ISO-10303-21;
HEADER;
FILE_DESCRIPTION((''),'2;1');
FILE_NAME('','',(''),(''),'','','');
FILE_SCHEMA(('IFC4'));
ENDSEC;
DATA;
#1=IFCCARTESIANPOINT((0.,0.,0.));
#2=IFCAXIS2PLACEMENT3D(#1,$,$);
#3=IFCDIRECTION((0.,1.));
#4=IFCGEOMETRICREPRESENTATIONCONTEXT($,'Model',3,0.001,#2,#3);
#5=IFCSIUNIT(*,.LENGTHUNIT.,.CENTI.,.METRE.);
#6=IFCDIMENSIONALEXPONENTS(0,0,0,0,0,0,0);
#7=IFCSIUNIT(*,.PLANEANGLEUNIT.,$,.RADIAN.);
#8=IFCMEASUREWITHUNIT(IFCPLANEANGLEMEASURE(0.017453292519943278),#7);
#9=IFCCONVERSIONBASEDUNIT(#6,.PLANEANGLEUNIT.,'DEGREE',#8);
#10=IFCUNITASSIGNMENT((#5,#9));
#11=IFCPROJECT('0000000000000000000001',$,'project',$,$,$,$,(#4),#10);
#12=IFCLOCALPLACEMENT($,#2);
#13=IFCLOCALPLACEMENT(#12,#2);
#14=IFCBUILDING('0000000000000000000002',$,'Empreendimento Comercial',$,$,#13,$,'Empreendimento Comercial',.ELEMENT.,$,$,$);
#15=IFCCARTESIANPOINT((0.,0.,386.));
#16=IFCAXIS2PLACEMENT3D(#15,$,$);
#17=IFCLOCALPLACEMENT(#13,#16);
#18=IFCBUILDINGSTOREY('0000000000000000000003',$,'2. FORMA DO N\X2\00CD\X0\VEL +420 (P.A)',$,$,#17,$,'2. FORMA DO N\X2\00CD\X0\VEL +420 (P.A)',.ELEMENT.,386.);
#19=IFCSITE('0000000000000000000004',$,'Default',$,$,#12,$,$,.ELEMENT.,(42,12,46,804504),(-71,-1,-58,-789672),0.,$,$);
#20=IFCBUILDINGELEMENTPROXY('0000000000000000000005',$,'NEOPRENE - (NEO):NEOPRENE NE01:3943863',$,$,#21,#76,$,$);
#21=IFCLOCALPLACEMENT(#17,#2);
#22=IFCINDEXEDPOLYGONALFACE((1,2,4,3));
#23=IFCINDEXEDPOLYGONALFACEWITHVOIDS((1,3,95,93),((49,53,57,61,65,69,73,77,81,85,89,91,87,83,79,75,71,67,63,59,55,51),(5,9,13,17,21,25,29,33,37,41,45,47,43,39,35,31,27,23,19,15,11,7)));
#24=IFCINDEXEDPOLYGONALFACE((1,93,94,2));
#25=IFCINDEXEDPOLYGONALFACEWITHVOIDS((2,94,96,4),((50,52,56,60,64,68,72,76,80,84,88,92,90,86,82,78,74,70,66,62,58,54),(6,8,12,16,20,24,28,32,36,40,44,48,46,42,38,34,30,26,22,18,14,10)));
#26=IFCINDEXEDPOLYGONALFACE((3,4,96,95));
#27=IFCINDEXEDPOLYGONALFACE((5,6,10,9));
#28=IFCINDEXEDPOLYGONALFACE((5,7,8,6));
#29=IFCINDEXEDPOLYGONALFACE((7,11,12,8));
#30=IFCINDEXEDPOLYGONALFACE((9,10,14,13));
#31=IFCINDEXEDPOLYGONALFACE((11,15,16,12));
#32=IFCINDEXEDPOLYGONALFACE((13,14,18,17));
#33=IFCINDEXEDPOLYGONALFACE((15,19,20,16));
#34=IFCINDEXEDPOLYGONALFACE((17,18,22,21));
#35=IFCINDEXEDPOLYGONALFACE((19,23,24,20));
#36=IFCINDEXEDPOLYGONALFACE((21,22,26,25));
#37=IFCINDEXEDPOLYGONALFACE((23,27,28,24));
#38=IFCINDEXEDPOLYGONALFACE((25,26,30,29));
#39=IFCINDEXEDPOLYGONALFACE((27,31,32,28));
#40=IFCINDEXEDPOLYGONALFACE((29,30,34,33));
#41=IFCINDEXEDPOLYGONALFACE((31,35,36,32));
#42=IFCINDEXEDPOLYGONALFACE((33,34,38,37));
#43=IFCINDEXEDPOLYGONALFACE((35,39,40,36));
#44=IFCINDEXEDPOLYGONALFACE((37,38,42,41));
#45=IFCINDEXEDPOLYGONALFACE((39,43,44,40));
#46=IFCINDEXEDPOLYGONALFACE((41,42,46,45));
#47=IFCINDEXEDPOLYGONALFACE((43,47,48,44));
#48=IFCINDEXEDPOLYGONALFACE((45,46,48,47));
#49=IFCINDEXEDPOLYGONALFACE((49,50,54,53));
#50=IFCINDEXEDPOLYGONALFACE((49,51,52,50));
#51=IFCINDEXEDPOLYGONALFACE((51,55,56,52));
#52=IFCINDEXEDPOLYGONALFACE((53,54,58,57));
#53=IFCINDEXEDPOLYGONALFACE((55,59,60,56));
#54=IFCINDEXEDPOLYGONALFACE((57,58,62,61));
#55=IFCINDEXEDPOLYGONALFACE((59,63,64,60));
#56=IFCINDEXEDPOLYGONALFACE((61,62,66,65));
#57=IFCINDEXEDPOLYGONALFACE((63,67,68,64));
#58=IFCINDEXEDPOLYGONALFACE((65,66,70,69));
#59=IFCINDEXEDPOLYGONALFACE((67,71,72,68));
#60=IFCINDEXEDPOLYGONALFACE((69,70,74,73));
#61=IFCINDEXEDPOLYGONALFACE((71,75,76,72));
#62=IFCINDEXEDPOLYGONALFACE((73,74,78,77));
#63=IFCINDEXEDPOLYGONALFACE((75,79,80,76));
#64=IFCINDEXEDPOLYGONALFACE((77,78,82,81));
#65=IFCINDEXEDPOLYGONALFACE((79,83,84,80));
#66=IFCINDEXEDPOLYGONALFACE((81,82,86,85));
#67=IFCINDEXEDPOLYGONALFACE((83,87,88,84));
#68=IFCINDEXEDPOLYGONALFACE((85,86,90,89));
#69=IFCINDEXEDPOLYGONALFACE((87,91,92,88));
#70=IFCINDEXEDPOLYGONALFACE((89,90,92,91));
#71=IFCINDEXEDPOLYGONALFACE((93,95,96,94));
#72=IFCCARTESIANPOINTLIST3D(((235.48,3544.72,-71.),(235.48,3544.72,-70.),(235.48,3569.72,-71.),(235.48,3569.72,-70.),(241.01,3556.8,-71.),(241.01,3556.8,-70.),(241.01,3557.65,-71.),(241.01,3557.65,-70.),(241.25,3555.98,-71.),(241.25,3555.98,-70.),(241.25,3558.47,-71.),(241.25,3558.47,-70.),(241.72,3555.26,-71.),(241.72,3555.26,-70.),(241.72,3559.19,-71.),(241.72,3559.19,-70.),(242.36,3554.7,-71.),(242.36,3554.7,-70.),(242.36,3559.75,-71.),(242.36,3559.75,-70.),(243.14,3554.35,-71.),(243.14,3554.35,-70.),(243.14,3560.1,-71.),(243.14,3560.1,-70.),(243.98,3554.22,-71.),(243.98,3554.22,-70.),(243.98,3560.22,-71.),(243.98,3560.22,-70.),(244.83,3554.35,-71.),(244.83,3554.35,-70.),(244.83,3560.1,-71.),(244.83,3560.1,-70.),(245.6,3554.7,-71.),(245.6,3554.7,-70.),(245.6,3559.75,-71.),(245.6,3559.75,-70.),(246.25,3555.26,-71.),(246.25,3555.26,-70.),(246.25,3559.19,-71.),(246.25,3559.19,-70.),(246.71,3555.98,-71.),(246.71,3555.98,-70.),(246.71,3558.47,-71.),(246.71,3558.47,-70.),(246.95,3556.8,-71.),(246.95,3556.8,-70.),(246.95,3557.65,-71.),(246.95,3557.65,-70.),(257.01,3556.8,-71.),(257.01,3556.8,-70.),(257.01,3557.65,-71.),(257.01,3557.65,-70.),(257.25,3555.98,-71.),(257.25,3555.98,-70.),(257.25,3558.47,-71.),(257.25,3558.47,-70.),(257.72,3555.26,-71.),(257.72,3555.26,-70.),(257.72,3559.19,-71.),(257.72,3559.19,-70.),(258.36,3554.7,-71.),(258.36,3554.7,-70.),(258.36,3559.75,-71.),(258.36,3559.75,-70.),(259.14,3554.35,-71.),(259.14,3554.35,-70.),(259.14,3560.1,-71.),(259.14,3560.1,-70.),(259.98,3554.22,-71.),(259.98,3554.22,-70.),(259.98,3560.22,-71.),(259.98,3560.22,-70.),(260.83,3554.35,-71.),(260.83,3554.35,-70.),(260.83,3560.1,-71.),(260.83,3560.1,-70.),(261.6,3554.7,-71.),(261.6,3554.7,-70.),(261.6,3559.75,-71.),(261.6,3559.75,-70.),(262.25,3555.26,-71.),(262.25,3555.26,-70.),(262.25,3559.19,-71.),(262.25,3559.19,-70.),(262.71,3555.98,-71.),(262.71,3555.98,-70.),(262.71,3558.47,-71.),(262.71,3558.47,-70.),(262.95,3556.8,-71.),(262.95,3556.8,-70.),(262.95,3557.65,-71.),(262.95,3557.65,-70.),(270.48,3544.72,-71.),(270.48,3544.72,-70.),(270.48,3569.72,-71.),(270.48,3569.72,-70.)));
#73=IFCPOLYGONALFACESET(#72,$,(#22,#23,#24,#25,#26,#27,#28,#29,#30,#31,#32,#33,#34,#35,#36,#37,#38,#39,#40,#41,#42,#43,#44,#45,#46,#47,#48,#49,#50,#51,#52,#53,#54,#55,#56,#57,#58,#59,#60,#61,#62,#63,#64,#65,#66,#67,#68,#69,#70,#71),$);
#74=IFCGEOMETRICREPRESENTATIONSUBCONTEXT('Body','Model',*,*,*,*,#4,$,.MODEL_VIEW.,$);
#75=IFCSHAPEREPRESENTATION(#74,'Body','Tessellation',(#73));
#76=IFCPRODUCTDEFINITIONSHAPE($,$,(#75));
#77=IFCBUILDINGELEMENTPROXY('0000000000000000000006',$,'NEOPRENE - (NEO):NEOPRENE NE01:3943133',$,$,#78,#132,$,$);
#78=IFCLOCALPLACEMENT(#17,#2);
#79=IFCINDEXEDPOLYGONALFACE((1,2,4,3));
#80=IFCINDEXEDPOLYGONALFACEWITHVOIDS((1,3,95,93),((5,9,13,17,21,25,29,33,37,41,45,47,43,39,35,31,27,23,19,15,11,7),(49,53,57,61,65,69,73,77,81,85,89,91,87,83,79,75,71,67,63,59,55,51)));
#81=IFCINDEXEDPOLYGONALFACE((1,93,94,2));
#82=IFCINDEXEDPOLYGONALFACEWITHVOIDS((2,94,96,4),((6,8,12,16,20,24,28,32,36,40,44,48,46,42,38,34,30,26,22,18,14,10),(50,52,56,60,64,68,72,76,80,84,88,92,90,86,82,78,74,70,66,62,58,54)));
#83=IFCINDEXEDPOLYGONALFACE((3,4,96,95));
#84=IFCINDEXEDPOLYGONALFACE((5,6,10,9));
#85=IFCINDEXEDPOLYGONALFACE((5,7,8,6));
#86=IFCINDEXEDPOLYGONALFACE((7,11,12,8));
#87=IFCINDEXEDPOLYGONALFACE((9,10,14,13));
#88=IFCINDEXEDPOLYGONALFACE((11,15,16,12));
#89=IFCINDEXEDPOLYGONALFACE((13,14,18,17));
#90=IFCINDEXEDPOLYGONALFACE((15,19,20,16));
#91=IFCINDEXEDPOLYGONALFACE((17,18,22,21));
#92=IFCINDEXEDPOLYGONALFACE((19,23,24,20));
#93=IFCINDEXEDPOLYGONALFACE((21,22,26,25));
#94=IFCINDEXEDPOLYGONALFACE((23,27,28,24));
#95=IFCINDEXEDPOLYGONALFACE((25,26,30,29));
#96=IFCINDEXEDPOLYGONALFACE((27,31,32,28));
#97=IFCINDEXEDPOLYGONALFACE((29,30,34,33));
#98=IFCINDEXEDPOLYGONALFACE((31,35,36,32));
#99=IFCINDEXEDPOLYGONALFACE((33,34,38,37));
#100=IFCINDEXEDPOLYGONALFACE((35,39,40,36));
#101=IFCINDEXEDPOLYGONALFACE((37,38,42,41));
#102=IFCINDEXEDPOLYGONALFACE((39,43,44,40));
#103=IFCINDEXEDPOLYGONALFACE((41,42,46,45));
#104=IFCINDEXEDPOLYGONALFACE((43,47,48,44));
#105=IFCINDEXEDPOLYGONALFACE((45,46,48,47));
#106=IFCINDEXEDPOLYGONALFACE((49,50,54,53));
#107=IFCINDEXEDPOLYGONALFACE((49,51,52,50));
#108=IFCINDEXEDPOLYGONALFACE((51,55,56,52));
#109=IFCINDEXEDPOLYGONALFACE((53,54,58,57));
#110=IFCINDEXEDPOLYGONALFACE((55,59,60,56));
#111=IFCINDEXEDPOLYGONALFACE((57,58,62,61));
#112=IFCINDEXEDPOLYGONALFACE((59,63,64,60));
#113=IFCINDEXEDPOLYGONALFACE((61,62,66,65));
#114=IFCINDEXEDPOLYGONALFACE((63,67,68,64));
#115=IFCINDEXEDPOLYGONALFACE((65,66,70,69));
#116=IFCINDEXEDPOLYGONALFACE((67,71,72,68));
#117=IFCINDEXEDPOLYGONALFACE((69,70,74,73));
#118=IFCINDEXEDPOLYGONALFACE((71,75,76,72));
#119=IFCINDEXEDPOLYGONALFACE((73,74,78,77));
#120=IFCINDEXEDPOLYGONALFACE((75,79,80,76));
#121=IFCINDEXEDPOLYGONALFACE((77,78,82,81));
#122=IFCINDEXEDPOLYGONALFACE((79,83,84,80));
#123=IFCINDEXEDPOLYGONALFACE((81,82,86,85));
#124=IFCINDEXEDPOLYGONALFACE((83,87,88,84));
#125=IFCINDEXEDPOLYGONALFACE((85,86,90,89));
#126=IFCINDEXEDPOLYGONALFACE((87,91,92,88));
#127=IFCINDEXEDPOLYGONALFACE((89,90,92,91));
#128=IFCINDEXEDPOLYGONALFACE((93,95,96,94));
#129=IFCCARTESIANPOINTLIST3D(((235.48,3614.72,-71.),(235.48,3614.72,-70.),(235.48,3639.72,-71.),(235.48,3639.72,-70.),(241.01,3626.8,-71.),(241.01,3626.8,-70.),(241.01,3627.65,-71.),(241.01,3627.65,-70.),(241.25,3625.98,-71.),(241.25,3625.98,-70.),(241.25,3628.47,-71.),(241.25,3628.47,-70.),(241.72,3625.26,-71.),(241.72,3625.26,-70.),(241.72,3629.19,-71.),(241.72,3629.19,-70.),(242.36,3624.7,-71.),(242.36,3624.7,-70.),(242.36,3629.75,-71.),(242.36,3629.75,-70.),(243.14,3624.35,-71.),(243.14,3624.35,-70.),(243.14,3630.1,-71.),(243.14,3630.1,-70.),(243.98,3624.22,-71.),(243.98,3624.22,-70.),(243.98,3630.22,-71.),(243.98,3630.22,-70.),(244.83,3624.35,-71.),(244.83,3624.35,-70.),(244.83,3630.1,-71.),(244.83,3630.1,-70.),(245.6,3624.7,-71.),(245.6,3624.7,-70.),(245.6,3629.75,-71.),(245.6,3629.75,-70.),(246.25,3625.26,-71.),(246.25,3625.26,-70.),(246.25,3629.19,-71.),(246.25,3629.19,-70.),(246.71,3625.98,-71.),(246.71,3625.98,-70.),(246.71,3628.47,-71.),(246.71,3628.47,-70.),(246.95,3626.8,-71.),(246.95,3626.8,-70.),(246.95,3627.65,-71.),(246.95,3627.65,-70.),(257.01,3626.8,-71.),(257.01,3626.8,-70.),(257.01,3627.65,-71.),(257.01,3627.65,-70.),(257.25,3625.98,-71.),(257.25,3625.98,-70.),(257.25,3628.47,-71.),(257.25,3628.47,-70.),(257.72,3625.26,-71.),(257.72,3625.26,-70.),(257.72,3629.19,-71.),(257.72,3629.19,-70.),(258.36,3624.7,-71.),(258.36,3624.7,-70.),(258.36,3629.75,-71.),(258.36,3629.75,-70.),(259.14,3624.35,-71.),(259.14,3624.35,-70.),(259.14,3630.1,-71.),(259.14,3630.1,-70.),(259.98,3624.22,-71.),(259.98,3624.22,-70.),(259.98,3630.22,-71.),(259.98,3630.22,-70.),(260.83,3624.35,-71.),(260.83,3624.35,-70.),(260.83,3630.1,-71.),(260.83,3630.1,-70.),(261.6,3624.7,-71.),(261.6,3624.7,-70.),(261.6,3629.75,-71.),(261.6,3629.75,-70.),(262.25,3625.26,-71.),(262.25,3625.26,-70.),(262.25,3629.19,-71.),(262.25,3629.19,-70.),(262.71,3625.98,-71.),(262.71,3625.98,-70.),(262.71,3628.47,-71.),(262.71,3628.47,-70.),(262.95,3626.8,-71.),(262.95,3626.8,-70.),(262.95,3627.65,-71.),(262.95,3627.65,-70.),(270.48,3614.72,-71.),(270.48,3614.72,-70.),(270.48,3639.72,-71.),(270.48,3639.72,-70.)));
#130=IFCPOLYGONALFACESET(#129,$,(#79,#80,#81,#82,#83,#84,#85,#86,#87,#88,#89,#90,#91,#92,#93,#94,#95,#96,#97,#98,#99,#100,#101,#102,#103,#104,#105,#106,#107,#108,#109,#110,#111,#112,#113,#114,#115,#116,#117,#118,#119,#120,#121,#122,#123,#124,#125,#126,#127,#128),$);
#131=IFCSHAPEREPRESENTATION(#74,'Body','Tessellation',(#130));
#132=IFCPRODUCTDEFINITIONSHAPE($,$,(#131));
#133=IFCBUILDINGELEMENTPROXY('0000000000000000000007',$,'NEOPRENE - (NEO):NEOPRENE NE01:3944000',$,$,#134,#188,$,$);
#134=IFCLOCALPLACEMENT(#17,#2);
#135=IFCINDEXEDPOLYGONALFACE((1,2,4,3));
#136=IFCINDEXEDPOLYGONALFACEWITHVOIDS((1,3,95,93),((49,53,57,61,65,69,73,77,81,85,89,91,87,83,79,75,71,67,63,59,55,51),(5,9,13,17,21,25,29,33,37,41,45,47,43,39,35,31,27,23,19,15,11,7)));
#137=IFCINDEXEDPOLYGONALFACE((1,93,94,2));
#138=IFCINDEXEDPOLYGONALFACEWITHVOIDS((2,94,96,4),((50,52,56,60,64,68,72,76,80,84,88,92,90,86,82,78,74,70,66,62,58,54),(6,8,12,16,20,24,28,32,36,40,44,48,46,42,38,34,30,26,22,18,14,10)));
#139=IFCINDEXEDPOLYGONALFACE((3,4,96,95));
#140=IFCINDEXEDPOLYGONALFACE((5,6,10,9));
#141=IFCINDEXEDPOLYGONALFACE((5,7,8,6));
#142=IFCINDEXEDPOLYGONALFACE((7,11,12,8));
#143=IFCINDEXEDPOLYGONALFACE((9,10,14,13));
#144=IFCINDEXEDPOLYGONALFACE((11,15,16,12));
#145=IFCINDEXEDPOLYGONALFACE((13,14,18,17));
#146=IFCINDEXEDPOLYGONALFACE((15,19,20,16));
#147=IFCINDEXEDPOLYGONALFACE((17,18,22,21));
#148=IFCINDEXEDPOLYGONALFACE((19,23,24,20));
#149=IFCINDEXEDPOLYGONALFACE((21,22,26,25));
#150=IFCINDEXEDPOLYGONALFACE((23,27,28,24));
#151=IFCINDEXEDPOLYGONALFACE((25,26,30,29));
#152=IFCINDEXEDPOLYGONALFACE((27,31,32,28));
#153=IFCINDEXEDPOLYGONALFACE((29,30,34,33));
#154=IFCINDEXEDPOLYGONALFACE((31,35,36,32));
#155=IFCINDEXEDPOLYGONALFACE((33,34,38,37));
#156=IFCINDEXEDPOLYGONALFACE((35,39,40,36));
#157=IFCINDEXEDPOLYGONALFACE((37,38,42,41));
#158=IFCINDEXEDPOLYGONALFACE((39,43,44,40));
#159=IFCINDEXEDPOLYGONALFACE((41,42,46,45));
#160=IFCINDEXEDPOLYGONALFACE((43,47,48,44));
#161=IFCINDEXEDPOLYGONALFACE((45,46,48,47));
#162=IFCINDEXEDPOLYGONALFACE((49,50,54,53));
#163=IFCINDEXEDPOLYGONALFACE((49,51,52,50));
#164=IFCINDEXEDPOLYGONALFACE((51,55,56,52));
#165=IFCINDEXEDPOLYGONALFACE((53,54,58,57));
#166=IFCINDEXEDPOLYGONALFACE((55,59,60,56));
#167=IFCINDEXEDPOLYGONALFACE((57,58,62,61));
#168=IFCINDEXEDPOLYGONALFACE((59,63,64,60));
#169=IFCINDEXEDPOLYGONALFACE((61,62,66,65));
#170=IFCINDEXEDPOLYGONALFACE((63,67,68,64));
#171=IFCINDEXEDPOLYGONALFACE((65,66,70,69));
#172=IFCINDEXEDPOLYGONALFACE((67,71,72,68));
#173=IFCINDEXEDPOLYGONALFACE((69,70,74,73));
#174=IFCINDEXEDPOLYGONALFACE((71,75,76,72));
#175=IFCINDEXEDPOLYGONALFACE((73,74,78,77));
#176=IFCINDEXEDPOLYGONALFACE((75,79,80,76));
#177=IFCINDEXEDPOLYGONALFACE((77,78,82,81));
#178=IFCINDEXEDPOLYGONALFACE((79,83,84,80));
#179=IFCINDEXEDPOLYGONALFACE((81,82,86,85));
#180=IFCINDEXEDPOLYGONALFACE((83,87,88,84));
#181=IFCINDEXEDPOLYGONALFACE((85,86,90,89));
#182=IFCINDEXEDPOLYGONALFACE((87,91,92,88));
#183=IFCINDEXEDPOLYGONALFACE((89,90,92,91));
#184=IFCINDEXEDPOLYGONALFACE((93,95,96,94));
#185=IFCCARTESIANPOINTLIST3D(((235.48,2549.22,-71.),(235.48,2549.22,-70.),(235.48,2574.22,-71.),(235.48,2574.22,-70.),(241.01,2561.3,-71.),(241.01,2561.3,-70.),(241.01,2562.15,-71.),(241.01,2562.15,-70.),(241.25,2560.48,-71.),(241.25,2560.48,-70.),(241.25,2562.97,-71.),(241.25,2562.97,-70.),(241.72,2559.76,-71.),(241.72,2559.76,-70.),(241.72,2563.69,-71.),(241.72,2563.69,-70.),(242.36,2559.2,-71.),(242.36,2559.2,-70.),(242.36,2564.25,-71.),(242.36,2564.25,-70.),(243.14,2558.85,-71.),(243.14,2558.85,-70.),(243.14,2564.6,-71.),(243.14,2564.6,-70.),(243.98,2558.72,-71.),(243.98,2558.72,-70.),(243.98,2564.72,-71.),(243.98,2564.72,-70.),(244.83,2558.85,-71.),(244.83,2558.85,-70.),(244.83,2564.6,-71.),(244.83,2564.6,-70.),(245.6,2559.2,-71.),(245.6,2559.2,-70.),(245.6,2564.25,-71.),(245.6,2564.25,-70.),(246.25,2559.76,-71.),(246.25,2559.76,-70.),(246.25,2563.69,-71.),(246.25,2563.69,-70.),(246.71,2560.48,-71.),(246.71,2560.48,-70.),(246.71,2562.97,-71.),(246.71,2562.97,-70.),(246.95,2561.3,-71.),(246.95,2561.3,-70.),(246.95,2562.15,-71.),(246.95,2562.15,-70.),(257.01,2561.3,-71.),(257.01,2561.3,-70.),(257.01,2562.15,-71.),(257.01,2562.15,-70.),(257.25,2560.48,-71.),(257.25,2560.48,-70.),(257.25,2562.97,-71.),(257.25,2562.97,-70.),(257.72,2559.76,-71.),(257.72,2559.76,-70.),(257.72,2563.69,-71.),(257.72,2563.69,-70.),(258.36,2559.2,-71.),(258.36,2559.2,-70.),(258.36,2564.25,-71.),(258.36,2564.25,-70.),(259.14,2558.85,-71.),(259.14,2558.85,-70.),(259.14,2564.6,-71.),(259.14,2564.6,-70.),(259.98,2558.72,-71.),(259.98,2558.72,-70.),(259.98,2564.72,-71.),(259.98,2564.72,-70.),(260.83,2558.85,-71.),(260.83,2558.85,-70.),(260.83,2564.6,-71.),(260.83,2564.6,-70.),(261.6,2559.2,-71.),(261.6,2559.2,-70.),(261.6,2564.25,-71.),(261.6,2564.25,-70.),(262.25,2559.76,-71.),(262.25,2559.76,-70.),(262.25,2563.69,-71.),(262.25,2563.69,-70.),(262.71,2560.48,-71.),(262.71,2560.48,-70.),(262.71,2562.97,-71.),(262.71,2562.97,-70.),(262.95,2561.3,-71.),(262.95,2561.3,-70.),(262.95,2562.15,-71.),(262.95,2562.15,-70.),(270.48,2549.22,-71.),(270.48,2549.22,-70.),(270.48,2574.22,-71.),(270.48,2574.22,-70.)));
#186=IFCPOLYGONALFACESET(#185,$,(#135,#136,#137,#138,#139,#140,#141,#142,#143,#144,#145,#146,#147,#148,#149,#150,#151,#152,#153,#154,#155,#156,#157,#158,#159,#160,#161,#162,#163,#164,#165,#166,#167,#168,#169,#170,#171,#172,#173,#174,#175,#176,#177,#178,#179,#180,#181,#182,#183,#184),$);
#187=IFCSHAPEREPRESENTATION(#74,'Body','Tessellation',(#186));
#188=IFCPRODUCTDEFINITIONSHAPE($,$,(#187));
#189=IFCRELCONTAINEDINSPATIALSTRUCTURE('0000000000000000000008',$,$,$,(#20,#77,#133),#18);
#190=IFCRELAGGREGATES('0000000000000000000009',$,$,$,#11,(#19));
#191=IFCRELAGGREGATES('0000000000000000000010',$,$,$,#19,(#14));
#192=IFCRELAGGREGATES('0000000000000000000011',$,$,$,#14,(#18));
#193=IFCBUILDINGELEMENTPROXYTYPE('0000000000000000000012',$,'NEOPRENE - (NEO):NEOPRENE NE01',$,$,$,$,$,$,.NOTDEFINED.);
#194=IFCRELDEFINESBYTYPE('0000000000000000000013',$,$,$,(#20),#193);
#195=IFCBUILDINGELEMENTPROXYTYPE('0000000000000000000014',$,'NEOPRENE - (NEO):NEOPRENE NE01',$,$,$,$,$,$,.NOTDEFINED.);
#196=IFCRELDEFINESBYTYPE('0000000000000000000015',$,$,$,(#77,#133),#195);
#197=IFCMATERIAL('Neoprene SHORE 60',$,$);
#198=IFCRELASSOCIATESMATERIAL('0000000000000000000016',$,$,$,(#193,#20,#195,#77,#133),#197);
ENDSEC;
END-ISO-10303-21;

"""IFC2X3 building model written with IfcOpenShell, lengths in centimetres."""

from ifc_helpers import new_model, entity, si_unit, converted_unit, direction, frame, frame_2d, origin, place, context, subcontext, project, spatial, polyline, circle_curve, parameter, trimmed, segment, composite_curve, outline, extrude, source, transform, mapped, material, type_object, type_shapes, element, save


model = new_model("IFC2X3")

# Units and contexts
model_context = context("Model", 3, precision=0.001, world=origin(), true_north=direction((0.0, 1.0)))
body_context = subcontext(model_context, "Body", "Model", "MODEL_VIEW")
ifc_project = project(units=[si_unit("LENGTHUNIT", "METRE", prefix="CENTI"), converted_unit("PLANEANGLEUNIT", "DEGREE", entity("IfcPlaneAngleMeasure", 0.017453292519943278), si_unit("PLANEANGLEUNIT", "RADIAN"), dimensions=[0, 0, 0, 0, 0, 0, 0])], contexts=[model_context])

# Site, building, storey
site_placement = place(None, origin())
site = spatial("IfcSite", under=ifc_project, at=site_placement, Name="Default", CompositionType="ELEMENT", RefLatitude=(42, 12, 46, 804504), RefLongitude=(-71, -1, -58, -789672), RefElevation=0.0)
building_placement = place(site_placement, origin())
building = spatial("IfcBuilding", under=site, at=building_placement, Name="Empreendimento Comercial", LongName="Empreendimento Comercial", CompositionType="ELEMENT")
storey_placement = place(building_placement, frame((0.0, 0.0, 386.0)))
storey = spatial("IfcBuildingStorey", under=building, at=storey_placement, Name="2. FORMA DO NÍVEL +420 (P.A)", LongName="2. FORMA DO NÍVEL +420 (P.A)", CompositionType="ELEMENT", Elevation=386.0)

# Building element proxies
ifc_material = material(Name="Neoprene SHORE 60")
building_element_proxy_type_1 = type_object("IfcBuildingElementProxyType", Name="NEOPRENE - (NEO):NEOPRENE NE01", PredefinedType="NOTDEFINED", material=ifc_material)
shared_shape_1 = source(origin(), body_context, "Body", "SweptSolid", [
    extrude(outline(polyline([(-17.5, -12.5), (17.5, -12.5), (17.5, 12.5), (-17.5, 12.5), (-17.5, -12.5)]), holes=[composite_curve([segment(trimmed(circle_curve(frame_2d((-7.0, 0.0), x_axis=(0.0, -1.0)), 3.0), [parameter(0.0)], [parameter(180.0)], True, "PARAMETER"), False, "CONTINUOUS"), segment(trimmed(circle_curve(frame_2d((-7.0, 0.0), x_axis=(0.0, -1.0)), 3.0), [parameter(180.0)], [parameter(0.0)], True, "PARAMETER"), False, "CONTINUOUS")], self_intersect=False), composite_curve([segment(trimmed(circle_curve(frame_2d((9.0, 0.0), x_axis=(0.0, -1.0)), 3.0), [parameter(0.0)], [parameter(180.0)], True, "PARAMETER"), False, "CONTINUOUS"), segment(trimmed(circle_curve(frame_2d((9.0, 0.0), x_axis=(0.0, -1.0)), 3.0), [parameter(180.0)], [parameter(0.0)], True, "PARAMETER"), False, "CONTINUOUS")], self_intersect=False)]), frame((0.0, 0.0, -71.0), z_axis=(0.0, 0.0, 1.0), x_axis=(0.0, 1.0, 0.0)), (0.0, 0.0, 1.0), 1.0),
])
type_shapes(building_element_proxy_type_1, [shared_shape_1])
for number, where, z_axis, x_axis, name in (
    (1, (252.98, 3557.22, 0.0), (0.0, 0.0, 1.0), (0.0, 1.0, 0.0), "NEOPRENE - (NEO):NEOPRENE NE01:3943863"),
):
    element("IfcBuildingElementProxy", number, at=place(storey_placement, frame(where, z_axis=z_axis, x_axis=x_axis)), inside=storey, type_object=building_element_proxy_type_1, material=ifc_material, Name=name, context=body_context, shape_type="MappedRepresentation", body=[
        mapped(shared_shape_1, transform((0.0, 0.0, 0.0), scale=1.0)),
    ])
building_element_proxy_type_2 = type_object("IfcBuildingElementProxyType", Name="NEOPRENE - (NEO):NEOPRENE NE01", PredefinedType="NOTDEFINED", material=ifc_material)
shared_shape_2 = source(origin(), body_context, "Body", "SweptSolid", [
    extrude(outline(polyline([(-12.5, -17.5), (12.5, -17.5), (12.5, 17.5), (-12.5, 17.5), (-12.5, -17.5)]), holes=[composite_curve([segment(trimmed(circle_curve(frame_2d((0.0, -7.0), x_axis=(-1.0, 0.0)), 3.0), [parameter(0.0)], [parameter(180.0)], True, "PARAMETER"), False, "CONTINUOUS"), segment(trimmed(circle_curve(frame_2d((0.0, -7.0), x_axis=(-1.0, 0.0)), 3.0), [parameter(180.0)], [parameter(0.0)], True, "PARAMETER"), False, "CONTINUOUS")], self_intersect=False), composite_curve([segment(trimmed(circle_curve(frame_2d((0.0, 9.0), x_axis=(-1.0, 0.0)), 3.0), [parameter(0.0)], [parameter(180.0)], True, "PARAMETER"), False, "CONTINUOUS"), segment(trimmed(circle_curve(frame_2d((0.0, 9.0), x_axis=(-1.0, 0.0)), 3.0), [parameter(180.0)], [parameter(0.0)], True, "PARAMETER"), False, "CONTINUOUS")], self_intersect=False)]), frame((0.0, 0.0, -71.0), z_axis=(0.0, 0.0, 1.0), x_axis=(-1.0, 0.0, 0.0)), (0.0, 0.0, 1.0), 1.0),
])
type_shapes(building_element_proxy_type_2, [shared_shape_2])
for number, where, z_axis, x_axis, name in (
    (2, (252.98, 3627.22, 0.0), (0.0, 0.0, 1.0), (0.0, -1.0, 0.0), "NEOPRENE - (NEO):NEOPRENE NE01:3943133"),
    (3, (252.98, 2561.72, 0.0), (0.0, 0.0, 1.0), (0.0, -1.0, 0.0), "NEOPRENE - (NEO):NEOPRENE NE01:3944000"),
):
    element("IfcBuildingElementProxy", number, at=place(storey_placement, frame(where, z_axis=z_axis, x_axis=x_axis)), inside=storey, type_object=building_element_proxy_type_2, material=ifc_material, Name=name, context=body_context, shape_type="MappedRepresentation", body=[
        mapped(shared_shape_2, transform((0.0, 0.0, 0.0), scale=1.0)),
    ])

save(model, "model.ifc")
